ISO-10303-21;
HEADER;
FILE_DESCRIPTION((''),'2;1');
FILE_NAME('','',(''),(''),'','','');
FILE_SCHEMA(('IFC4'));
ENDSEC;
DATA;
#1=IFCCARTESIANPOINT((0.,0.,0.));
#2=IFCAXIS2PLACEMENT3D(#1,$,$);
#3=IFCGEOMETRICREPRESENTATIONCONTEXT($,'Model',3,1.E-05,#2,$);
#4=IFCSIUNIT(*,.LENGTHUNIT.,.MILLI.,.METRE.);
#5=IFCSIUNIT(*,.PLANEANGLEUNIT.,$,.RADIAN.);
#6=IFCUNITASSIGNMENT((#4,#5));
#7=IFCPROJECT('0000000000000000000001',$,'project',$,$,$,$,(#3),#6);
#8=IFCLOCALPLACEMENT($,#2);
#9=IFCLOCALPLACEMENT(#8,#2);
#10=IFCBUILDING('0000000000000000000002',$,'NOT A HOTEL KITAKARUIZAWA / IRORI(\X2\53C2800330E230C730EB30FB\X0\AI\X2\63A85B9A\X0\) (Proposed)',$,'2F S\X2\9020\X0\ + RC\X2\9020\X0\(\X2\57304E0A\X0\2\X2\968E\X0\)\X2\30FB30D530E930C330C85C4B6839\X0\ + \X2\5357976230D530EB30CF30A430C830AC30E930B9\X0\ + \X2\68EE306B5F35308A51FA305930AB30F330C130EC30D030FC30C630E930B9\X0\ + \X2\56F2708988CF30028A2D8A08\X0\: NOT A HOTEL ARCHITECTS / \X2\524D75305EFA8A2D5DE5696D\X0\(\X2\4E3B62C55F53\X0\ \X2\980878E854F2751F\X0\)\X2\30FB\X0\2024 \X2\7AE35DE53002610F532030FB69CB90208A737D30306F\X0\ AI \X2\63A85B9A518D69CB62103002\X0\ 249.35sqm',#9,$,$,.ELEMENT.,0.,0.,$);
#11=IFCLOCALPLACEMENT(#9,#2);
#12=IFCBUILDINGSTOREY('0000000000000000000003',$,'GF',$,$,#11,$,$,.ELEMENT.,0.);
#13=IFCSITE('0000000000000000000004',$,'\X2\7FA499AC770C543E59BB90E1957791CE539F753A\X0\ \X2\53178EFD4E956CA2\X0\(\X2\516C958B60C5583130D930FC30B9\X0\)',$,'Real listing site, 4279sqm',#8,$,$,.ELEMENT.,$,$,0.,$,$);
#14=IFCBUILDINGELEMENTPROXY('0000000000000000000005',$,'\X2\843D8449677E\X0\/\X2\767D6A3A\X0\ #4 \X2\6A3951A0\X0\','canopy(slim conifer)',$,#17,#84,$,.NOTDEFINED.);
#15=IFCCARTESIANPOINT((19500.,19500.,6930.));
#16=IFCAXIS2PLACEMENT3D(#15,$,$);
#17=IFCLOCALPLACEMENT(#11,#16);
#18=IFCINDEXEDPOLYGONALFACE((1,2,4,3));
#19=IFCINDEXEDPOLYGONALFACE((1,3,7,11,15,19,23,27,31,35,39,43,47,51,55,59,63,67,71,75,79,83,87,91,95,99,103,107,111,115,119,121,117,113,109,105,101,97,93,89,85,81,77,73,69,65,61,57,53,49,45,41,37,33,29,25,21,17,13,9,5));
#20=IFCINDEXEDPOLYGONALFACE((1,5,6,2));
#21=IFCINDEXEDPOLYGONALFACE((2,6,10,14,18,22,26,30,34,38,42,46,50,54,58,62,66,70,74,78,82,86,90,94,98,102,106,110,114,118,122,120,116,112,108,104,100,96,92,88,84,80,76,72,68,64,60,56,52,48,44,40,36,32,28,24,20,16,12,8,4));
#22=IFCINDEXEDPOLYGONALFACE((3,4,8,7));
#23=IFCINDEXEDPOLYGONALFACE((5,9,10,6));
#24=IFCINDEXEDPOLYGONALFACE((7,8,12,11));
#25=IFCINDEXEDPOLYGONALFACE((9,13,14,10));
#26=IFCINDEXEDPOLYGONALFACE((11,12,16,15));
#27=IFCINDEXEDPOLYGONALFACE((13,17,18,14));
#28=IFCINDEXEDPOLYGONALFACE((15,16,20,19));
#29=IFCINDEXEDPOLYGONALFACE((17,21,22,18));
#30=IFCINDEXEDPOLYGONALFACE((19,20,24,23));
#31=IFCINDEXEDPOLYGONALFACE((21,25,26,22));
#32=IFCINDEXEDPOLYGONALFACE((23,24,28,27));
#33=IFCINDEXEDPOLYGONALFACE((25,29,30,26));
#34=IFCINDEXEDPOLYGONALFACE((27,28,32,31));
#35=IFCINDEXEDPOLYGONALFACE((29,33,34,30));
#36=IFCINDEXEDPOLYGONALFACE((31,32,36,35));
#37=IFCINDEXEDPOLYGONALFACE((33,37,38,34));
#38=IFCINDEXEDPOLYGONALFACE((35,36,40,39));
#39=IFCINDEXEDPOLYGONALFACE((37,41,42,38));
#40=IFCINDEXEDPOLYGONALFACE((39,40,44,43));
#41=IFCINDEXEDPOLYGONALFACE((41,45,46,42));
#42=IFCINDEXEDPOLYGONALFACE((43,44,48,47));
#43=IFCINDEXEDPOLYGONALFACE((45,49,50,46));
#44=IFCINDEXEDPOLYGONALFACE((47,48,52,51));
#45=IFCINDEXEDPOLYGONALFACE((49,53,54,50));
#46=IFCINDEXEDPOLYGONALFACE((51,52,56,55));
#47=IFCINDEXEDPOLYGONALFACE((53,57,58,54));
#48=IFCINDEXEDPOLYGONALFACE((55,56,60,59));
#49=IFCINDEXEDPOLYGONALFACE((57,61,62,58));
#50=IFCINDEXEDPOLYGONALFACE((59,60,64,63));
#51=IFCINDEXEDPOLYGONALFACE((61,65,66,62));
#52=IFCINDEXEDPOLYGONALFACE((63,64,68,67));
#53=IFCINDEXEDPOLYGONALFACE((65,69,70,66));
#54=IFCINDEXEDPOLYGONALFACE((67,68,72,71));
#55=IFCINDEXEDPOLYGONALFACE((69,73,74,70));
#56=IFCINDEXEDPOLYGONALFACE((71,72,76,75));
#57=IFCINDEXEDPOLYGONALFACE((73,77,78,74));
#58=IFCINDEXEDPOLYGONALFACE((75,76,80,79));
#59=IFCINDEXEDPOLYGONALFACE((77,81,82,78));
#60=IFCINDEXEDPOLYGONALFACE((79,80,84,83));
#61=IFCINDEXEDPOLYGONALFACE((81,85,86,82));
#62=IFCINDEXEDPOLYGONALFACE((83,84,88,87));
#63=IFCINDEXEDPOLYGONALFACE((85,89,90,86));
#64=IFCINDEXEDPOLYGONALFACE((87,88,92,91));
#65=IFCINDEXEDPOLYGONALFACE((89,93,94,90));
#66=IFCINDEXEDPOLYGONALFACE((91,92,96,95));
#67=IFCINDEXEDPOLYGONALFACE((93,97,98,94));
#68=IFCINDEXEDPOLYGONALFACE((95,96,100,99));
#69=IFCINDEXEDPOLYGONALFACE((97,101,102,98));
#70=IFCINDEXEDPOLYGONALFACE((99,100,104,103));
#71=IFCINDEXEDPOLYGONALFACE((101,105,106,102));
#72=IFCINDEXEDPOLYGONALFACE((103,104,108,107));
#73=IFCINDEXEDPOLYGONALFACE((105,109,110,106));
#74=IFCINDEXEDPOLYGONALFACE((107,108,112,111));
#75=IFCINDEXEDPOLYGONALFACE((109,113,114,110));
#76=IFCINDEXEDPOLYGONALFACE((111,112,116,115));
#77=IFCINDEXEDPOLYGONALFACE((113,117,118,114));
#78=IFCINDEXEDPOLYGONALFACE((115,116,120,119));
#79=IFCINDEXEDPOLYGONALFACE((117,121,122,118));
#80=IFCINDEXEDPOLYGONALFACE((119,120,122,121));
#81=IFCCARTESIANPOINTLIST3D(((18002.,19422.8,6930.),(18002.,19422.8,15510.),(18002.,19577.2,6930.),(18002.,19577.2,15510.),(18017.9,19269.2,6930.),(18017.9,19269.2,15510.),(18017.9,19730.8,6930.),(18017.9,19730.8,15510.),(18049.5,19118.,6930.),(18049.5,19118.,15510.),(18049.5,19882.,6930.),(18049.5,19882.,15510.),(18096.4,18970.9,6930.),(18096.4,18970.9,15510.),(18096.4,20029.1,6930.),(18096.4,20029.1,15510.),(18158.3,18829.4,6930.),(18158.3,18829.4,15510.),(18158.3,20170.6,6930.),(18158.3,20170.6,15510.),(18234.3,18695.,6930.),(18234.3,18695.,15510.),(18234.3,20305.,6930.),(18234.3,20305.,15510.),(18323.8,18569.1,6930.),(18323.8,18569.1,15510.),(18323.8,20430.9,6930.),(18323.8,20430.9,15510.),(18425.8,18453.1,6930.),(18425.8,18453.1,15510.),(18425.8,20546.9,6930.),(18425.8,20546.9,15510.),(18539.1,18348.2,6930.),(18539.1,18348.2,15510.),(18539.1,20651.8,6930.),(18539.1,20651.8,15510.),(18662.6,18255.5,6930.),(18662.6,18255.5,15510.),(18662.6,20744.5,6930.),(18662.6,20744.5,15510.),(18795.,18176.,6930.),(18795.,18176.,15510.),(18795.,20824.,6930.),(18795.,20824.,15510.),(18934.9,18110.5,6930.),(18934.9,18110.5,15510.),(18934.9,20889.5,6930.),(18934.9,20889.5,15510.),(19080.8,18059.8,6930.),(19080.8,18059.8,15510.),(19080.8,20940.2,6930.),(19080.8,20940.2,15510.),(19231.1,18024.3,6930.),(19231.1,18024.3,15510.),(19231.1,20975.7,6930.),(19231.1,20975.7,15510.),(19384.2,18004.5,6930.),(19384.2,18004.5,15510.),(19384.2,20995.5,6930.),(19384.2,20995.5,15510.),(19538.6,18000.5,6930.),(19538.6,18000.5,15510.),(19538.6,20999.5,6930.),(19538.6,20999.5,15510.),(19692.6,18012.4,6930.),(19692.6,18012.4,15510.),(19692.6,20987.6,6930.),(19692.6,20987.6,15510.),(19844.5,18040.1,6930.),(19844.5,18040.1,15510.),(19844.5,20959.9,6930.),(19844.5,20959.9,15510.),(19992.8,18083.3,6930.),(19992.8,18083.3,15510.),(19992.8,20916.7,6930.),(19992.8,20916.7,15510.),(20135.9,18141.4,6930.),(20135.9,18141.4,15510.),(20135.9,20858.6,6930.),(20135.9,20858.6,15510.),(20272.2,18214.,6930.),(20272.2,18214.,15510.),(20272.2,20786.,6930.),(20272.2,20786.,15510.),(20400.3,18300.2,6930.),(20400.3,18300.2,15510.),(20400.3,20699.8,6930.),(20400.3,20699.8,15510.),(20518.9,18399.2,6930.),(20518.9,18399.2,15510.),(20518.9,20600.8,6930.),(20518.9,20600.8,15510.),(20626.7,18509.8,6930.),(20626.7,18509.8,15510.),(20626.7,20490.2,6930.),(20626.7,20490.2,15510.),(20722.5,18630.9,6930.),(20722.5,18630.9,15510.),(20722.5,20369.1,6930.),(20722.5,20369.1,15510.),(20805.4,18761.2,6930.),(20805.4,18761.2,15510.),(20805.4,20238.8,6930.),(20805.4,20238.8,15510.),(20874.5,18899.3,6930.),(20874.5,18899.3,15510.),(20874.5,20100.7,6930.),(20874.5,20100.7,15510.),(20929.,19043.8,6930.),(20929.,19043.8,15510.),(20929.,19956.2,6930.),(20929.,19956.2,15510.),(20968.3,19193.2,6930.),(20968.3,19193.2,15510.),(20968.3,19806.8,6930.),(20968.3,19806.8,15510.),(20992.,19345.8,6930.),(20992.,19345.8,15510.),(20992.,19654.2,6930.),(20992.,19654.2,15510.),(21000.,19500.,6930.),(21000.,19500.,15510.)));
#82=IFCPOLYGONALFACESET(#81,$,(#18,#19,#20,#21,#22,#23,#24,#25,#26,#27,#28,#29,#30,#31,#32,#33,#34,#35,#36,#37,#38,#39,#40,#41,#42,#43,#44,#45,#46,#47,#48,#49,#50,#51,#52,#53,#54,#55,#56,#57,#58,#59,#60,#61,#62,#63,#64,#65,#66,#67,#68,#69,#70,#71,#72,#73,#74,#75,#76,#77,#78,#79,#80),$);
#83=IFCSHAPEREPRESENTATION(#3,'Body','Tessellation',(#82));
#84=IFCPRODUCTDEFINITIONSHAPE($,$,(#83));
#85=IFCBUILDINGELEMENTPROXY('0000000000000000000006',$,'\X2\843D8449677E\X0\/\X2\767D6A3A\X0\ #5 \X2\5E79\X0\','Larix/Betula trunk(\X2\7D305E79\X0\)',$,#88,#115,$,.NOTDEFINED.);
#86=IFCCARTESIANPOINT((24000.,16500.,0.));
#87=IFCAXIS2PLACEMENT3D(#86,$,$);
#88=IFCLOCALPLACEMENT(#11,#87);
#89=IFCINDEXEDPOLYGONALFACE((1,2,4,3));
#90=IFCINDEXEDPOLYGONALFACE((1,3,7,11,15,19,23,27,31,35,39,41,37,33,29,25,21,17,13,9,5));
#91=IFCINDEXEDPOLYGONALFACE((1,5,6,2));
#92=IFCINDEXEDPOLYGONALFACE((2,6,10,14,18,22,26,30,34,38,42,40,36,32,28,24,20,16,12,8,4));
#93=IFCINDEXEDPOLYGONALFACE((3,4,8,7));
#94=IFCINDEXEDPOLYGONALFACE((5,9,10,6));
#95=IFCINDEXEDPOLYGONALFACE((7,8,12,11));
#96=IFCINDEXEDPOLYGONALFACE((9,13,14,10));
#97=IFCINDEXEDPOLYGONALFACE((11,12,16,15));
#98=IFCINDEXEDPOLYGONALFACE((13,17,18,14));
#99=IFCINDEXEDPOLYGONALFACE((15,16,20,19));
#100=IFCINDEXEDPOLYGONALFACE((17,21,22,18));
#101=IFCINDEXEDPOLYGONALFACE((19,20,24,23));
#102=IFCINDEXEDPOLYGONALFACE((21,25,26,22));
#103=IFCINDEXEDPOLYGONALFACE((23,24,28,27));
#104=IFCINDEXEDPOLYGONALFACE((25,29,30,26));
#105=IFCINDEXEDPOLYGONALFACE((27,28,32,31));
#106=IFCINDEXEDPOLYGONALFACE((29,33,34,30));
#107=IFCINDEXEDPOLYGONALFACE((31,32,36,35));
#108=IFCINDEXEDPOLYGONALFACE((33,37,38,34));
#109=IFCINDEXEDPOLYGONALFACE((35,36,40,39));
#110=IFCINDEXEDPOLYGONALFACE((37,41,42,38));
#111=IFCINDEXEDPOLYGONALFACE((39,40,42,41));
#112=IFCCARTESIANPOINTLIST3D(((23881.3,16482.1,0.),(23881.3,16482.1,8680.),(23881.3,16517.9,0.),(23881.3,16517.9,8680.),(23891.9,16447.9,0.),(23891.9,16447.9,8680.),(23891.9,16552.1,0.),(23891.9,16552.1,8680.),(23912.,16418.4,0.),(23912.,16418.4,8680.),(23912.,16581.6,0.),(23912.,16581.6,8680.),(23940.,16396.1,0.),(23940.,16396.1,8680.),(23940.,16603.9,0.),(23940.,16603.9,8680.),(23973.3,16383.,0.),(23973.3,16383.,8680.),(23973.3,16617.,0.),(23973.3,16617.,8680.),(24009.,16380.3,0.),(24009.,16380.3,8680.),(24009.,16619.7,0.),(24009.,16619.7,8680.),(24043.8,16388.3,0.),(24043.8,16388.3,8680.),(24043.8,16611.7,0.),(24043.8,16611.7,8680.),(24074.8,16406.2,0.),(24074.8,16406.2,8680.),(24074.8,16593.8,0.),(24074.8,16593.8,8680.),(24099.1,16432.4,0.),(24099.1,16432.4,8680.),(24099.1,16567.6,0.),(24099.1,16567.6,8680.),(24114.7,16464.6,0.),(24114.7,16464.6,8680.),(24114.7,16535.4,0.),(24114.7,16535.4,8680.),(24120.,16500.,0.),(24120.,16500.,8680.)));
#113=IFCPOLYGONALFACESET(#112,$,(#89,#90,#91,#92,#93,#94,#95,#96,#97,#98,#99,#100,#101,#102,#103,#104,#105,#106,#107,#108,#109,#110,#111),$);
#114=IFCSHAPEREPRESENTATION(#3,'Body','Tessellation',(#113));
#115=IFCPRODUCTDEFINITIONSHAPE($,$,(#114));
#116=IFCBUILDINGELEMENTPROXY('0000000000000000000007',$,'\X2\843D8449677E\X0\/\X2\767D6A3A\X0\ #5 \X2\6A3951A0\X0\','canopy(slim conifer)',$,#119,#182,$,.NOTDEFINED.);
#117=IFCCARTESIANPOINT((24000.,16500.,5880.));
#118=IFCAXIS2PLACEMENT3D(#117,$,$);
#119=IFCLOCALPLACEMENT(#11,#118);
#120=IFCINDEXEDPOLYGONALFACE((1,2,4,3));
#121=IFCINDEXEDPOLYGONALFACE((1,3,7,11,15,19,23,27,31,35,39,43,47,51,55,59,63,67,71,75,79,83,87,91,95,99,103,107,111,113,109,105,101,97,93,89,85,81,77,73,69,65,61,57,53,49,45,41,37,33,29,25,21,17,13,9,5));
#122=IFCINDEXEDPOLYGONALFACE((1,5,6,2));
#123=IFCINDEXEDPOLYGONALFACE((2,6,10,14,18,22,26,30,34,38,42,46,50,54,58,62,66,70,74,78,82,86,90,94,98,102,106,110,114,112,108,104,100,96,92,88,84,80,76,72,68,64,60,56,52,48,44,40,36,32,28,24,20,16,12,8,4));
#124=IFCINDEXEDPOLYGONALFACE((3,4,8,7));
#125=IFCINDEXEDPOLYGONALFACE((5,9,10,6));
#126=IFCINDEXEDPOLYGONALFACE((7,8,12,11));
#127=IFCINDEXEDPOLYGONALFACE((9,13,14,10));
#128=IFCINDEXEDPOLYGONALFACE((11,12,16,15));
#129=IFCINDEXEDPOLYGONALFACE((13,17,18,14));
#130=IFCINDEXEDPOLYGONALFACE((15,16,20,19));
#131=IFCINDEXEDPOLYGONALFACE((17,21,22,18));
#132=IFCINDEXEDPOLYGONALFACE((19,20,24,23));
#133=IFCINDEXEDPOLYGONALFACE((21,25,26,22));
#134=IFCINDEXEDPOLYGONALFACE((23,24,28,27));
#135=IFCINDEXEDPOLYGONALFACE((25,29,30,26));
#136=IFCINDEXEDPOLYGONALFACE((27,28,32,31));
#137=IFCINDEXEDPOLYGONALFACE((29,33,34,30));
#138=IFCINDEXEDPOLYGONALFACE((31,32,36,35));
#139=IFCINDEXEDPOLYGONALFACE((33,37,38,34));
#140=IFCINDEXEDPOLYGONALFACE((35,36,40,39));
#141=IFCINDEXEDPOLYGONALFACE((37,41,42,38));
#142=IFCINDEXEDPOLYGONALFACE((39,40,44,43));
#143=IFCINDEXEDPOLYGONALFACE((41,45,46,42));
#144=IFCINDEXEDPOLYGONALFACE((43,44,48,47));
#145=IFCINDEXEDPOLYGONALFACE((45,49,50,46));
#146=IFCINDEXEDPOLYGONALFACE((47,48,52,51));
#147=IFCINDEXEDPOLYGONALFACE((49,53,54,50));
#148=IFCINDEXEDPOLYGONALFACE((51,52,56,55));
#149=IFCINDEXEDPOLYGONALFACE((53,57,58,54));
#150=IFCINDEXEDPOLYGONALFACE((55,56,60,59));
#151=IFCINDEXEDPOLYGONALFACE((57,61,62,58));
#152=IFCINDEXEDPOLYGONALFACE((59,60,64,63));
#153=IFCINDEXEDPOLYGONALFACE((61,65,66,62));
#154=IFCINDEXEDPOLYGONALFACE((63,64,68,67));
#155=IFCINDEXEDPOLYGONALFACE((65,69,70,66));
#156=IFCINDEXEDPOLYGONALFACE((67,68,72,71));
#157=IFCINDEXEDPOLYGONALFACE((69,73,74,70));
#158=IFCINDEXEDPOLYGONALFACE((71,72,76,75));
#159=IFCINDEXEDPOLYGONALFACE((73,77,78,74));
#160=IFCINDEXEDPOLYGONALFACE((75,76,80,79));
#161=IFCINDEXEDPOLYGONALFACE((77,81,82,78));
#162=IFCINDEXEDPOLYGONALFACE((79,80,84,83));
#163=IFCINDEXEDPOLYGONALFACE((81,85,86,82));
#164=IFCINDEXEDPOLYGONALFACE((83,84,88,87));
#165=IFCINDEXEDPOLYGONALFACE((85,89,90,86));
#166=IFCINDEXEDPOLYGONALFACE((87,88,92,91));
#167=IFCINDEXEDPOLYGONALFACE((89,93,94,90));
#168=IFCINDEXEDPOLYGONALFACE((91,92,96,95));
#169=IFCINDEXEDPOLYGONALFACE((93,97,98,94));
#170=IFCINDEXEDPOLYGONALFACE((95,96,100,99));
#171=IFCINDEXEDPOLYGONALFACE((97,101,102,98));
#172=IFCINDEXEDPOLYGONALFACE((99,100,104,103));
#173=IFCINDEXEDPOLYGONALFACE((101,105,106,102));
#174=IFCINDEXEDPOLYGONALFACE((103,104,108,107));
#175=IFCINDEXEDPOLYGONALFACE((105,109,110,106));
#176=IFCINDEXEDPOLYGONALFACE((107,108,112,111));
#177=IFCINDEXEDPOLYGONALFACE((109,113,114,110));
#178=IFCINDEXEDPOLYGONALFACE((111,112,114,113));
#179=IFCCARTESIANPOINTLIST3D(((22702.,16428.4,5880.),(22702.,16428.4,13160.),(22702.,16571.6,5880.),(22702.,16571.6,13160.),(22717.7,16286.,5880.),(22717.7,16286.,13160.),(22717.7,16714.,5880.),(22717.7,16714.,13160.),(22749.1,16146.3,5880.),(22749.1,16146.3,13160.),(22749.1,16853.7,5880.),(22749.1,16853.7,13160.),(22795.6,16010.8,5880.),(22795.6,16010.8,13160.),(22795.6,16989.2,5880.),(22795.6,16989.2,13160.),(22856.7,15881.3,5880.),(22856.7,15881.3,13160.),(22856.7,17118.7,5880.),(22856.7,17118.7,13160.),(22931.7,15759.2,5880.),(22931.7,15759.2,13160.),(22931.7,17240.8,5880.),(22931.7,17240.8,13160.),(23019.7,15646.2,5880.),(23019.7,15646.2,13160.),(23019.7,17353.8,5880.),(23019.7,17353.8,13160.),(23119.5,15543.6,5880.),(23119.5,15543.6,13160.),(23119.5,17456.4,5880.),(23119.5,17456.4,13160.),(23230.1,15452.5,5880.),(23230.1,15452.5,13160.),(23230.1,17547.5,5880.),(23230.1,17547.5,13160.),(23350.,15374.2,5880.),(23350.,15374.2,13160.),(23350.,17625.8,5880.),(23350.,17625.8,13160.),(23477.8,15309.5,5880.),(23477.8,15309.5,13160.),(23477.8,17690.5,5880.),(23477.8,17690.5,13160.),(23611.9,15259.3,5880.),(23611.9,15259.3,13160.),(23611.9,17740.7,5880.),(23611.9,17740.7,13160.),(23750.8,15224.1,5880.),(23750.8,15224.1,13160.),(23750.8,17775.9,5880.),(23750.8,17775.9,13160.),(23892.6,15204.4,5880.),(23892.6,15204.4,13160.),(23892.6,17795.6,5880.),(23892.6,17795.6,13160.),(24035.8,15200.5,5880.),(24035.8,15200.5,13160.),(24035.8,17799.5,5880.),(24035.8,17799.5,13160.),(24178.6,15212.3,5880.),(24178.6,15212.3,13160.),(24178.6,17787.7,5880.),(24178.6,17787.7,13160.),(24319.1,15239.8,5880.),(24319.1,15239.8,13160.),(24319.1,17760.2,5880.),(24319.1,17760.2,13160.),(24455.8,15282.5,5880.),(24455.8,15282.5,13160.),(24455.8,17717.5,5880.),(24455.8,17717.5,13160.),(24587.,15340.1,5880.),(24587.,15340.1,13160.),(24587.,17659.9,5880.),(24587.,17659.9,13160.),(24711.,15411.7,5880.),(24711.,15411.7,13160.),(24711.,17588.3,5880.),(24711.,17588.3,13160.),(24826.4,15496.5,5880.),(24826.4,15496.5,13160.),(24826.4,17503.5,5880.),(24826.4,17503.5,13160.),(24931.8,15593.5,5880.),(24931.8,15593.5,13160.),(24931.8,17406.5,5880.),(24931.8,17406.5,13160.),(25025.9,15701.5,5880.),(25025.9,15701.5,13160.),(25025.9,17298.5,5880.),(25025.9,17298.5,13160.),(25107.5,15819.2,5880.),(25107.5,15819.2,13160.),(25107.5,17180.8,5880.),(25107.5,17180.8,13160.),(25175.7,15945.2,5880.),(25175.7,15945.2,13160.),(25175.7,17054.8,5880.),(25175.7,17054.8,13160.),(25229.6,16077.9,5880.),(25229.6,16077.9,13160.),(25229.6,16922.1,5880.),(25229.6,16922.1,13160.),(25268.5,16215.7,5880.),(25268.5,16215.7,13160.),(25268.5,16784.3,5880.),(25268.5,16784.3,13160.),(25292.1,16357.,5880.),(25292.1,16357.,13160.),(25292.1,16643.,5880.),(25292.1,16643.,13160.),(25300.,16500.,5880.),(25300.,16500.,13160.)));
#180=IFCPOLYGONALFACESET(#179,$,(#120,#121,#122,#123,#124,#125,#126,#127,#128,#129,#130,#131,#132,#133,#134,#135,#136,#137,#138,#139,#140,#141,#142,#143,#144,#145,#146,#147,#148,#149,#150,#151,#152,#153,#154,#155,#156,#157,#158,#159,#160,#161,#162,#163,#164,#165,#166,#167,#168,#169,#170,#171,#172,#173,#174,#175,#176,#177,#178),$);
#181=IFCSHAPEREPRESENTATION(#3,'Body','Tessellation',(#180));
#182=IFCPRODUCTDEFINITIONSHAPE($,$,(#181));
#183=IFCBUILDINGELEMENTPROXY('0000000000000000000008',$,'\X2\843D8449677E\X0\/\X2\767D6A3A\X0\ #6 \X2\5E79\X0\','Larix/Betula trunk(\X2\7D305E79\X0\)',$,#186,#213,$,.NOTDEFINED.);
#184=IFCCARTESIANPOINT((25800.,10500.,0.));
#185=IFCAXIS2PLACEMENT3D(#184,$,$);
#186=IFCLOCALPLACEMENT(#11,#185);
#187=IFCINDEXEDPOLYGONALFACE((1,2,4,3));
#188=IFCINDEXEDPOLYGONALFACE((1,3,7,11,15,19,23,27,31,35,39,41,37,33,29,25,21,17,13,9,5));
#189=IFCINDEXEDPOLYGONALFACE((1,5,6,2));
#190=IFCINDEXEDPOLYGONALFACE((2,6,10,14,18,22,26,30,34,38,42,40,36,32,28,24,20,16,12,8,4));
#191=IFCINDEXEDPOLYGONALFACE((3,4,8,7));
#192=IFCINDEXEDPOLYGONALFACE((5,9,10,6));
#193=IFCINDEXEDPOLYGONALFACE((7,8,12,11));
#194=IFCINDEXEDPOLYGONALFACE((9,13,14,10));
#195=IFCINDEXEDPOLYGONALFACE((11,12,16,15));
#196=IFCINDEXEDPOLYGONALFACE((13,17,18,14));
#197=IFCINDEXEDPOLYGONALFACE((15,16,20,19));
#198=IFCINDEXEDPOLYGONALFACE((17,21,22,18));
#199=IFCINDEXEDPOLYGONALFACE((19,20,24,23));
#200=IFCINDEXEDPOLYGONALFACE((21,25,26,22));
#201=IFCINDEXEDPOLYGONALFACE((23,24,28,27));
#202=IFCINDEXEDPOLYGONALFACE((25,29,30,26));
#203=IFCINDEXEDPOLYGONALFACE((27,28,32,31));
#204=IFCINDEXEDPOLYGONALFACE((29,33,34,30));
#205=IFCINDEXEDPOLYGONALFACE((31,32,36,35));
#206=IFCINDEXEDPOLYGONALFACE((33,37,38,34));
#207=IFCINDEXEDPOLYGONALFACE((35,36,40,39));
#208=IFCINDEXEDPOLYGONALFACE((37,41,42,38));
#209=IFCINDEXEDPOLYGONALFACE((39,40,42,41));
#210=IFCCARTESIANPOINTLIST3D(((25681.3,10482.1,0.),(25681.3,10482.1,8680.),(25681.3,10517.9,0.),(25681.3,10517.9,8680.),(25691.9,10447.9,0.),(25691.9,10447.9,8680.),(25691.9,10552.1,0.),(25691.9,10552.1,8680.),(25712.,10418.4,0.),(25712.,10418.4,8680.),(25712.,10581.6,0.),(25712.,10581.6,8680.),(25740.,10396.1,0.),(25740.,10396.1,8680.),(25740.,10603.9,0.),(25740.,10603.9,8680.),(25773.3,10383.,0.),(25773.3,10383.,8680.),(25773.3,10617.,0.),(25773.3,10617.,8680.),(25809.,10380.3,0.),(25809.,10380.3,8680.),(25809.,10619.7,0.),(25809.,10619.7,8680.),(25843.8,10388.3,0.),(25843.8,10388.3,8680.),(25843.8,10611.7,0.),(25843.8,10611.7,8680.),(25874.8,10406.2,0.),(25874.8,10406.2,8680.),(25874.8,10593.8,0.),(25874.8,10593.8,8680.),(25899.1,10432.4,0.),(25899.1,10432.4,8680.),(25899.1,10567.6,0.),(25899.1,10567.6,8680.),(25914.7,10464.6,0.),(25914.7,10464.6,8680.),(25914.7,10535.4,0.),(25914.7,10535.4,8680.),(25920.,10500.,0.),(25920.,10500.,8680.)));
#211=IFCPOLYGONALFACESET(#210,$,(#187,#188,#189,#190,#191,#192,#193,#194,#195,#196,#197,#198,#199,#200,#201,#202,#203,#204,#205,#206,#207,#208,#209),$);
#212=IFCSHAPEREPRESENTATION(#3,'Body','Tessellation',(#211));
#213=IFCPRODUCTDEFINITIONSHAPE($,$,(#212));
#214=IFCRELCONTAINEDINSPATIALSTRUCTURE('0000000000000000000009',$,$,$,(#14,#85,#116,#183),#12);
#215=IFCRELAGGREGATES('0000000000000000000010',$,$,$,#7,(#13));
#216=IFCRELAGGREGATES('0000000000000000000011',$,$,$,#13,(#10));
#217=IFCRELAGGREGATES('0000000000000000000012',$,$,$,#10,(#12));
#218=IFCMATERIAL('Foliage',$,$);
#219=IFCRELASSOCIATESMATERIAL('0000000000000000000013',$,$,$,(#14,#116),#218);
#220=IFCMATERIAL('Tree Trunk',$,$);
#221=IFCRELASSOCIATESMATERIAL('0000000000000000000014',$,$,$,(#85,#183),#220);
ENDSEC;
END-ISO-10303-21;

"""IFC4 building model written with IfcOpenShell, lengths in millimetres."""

from ifc_helpers import new_model, si_unit, frame, origin, origin_2d, place, context, project, spatial, circle, extrude, material, element, save


model = new_model("IFC4")

# Units and contexts
model_context = context("Model", 3, precision=1e-05, world=origin())
ifc_project = project(units=[si_unit("LENGTHUNIT", "METRE", prefix="MILLI"), si_unit("PLANEANGLEUNIT", "RADIAN")], contexts=[model_context])

# Site, building, storey
site_placement = place(None, origin())
site = spatial("IfcSite", under=ifc_project, at=site_placement, Name="群馬県吾妻郡長野原町 北軽井沢(公開情報ベース)", ObjectType="Real listing site, 4279sqm", CompositionType="ELEMENT", RefElevation=0.0)
building_placement = place(site_placement, origin())
building = spatial("IfcBuilding", under=site, at=building_placement, Name="NOT A HOTEL KITAKARUIZAWA / IRORI(参考モデル・AI推定) (Proposed)", ObjectType="2F S造 + RC造(地上2階)・フラット屋根 + 南面フルハイトガラス + 森に張り出すカンチレバーテラス + 囲炉裏。設計: NOT A HOTEL ARCHITECTS / 前田建設工業(主担当 須磨哲生)・2024 竣工。意匠・構造詳細は AI 推定再構成。 249.35sqm", CompositionType="ELEMENT", ElevationOfRefHeight=0.0, ElevationOfTerrain=0.0)
storey_placement = place(building_placement, origin())
storey = spatial("IfcBuildingStorey", under=building, at=storey_placement, Name="GF", CompositionType="ELEMENT", Elevation=0.0)

# Building element proxies
ifc_material_1 = material(Name="Tree Trunk")
ifc_material_2 = material(Name="Foliage")
proxy_1_placement = place(storey_placement, frame((19500.0, 19500.0, 6930.0)))
element("IfcBuildingElementProxy", 1, at=proxy_1_placement, inside=storey, material=ifc_material_2, Name="落葉松/白樺 #4 樹冠", Description="canopy(slim conifer)", PredefinedType="NOTDEFINED", context=model_context, shape_type="SweptSolid", body=[
    extrude(circle(Radius=1500.0, at=origin_2d()), frame((19500.0, 19500.0, 6930.0)), (0.0, 0.0, 1.0), 8580.0),
])
proxy_2_placement = place(storey_placement, frame((24000.0, 16500.0, 0.0)))
element("IfcBuildingElementProxy", 2, at=proxy_2_placement, inside=storey, material=ifc_material_1, Name="落葉松/白樺 #5 幹", Description="Larix/Betula trunk(細幹)", PredefinedType="NOTDEFINED", context=model_context, shape_type="SweptSolid", body=[
    extrude(circle(Radius=120.0, at=origin_2d()), frame((24000.0, 16500.0, 0.0)), (0.0, 0.0, 1.0), 8680.0),
])
proxy_3_placement = place(storey_placement, frame((24000.0, 16500.0, 5880.0)))
element("IfcBuildingElementProxy", 3, at=proxy_3_placement, inside=storey, material=ifc_material_2, Name="落葉松/白樺 #5 樹冠", Description="canopy(slim conifer)", PredefinedType="NOTDEFINED", context=model_context, shape_type="SweptSolid", body=[
    extrude(circle(Radius=1300.0, at=origin_2d()), frame((24000.0, 16500.0, 5880.0)), (0.0, 0.0, 1.0), 7280.0),
])
proxy_4_placement = place(storey_placement, frame((25800.0, 10500.0, 0.0)))
element("IfcBuildingElementProxy", 4, at=proxy_4_placement, inside=storey, material=ifc_material_1, Name="落葉松/白樺 #6 幹", Description="Larix/Betula trunk(細幹)", PredefinedType="NOTDEFINED", context=model_context, shape_type="SweptSolid", body=[
    extrude(circle(Radius=120.0, at=origin_2d()), frame((25800.0, 10500.0, 0.0)), (0.0, 0.0, 1.0), 8680.0),
])

save(model, "model.ifc")
